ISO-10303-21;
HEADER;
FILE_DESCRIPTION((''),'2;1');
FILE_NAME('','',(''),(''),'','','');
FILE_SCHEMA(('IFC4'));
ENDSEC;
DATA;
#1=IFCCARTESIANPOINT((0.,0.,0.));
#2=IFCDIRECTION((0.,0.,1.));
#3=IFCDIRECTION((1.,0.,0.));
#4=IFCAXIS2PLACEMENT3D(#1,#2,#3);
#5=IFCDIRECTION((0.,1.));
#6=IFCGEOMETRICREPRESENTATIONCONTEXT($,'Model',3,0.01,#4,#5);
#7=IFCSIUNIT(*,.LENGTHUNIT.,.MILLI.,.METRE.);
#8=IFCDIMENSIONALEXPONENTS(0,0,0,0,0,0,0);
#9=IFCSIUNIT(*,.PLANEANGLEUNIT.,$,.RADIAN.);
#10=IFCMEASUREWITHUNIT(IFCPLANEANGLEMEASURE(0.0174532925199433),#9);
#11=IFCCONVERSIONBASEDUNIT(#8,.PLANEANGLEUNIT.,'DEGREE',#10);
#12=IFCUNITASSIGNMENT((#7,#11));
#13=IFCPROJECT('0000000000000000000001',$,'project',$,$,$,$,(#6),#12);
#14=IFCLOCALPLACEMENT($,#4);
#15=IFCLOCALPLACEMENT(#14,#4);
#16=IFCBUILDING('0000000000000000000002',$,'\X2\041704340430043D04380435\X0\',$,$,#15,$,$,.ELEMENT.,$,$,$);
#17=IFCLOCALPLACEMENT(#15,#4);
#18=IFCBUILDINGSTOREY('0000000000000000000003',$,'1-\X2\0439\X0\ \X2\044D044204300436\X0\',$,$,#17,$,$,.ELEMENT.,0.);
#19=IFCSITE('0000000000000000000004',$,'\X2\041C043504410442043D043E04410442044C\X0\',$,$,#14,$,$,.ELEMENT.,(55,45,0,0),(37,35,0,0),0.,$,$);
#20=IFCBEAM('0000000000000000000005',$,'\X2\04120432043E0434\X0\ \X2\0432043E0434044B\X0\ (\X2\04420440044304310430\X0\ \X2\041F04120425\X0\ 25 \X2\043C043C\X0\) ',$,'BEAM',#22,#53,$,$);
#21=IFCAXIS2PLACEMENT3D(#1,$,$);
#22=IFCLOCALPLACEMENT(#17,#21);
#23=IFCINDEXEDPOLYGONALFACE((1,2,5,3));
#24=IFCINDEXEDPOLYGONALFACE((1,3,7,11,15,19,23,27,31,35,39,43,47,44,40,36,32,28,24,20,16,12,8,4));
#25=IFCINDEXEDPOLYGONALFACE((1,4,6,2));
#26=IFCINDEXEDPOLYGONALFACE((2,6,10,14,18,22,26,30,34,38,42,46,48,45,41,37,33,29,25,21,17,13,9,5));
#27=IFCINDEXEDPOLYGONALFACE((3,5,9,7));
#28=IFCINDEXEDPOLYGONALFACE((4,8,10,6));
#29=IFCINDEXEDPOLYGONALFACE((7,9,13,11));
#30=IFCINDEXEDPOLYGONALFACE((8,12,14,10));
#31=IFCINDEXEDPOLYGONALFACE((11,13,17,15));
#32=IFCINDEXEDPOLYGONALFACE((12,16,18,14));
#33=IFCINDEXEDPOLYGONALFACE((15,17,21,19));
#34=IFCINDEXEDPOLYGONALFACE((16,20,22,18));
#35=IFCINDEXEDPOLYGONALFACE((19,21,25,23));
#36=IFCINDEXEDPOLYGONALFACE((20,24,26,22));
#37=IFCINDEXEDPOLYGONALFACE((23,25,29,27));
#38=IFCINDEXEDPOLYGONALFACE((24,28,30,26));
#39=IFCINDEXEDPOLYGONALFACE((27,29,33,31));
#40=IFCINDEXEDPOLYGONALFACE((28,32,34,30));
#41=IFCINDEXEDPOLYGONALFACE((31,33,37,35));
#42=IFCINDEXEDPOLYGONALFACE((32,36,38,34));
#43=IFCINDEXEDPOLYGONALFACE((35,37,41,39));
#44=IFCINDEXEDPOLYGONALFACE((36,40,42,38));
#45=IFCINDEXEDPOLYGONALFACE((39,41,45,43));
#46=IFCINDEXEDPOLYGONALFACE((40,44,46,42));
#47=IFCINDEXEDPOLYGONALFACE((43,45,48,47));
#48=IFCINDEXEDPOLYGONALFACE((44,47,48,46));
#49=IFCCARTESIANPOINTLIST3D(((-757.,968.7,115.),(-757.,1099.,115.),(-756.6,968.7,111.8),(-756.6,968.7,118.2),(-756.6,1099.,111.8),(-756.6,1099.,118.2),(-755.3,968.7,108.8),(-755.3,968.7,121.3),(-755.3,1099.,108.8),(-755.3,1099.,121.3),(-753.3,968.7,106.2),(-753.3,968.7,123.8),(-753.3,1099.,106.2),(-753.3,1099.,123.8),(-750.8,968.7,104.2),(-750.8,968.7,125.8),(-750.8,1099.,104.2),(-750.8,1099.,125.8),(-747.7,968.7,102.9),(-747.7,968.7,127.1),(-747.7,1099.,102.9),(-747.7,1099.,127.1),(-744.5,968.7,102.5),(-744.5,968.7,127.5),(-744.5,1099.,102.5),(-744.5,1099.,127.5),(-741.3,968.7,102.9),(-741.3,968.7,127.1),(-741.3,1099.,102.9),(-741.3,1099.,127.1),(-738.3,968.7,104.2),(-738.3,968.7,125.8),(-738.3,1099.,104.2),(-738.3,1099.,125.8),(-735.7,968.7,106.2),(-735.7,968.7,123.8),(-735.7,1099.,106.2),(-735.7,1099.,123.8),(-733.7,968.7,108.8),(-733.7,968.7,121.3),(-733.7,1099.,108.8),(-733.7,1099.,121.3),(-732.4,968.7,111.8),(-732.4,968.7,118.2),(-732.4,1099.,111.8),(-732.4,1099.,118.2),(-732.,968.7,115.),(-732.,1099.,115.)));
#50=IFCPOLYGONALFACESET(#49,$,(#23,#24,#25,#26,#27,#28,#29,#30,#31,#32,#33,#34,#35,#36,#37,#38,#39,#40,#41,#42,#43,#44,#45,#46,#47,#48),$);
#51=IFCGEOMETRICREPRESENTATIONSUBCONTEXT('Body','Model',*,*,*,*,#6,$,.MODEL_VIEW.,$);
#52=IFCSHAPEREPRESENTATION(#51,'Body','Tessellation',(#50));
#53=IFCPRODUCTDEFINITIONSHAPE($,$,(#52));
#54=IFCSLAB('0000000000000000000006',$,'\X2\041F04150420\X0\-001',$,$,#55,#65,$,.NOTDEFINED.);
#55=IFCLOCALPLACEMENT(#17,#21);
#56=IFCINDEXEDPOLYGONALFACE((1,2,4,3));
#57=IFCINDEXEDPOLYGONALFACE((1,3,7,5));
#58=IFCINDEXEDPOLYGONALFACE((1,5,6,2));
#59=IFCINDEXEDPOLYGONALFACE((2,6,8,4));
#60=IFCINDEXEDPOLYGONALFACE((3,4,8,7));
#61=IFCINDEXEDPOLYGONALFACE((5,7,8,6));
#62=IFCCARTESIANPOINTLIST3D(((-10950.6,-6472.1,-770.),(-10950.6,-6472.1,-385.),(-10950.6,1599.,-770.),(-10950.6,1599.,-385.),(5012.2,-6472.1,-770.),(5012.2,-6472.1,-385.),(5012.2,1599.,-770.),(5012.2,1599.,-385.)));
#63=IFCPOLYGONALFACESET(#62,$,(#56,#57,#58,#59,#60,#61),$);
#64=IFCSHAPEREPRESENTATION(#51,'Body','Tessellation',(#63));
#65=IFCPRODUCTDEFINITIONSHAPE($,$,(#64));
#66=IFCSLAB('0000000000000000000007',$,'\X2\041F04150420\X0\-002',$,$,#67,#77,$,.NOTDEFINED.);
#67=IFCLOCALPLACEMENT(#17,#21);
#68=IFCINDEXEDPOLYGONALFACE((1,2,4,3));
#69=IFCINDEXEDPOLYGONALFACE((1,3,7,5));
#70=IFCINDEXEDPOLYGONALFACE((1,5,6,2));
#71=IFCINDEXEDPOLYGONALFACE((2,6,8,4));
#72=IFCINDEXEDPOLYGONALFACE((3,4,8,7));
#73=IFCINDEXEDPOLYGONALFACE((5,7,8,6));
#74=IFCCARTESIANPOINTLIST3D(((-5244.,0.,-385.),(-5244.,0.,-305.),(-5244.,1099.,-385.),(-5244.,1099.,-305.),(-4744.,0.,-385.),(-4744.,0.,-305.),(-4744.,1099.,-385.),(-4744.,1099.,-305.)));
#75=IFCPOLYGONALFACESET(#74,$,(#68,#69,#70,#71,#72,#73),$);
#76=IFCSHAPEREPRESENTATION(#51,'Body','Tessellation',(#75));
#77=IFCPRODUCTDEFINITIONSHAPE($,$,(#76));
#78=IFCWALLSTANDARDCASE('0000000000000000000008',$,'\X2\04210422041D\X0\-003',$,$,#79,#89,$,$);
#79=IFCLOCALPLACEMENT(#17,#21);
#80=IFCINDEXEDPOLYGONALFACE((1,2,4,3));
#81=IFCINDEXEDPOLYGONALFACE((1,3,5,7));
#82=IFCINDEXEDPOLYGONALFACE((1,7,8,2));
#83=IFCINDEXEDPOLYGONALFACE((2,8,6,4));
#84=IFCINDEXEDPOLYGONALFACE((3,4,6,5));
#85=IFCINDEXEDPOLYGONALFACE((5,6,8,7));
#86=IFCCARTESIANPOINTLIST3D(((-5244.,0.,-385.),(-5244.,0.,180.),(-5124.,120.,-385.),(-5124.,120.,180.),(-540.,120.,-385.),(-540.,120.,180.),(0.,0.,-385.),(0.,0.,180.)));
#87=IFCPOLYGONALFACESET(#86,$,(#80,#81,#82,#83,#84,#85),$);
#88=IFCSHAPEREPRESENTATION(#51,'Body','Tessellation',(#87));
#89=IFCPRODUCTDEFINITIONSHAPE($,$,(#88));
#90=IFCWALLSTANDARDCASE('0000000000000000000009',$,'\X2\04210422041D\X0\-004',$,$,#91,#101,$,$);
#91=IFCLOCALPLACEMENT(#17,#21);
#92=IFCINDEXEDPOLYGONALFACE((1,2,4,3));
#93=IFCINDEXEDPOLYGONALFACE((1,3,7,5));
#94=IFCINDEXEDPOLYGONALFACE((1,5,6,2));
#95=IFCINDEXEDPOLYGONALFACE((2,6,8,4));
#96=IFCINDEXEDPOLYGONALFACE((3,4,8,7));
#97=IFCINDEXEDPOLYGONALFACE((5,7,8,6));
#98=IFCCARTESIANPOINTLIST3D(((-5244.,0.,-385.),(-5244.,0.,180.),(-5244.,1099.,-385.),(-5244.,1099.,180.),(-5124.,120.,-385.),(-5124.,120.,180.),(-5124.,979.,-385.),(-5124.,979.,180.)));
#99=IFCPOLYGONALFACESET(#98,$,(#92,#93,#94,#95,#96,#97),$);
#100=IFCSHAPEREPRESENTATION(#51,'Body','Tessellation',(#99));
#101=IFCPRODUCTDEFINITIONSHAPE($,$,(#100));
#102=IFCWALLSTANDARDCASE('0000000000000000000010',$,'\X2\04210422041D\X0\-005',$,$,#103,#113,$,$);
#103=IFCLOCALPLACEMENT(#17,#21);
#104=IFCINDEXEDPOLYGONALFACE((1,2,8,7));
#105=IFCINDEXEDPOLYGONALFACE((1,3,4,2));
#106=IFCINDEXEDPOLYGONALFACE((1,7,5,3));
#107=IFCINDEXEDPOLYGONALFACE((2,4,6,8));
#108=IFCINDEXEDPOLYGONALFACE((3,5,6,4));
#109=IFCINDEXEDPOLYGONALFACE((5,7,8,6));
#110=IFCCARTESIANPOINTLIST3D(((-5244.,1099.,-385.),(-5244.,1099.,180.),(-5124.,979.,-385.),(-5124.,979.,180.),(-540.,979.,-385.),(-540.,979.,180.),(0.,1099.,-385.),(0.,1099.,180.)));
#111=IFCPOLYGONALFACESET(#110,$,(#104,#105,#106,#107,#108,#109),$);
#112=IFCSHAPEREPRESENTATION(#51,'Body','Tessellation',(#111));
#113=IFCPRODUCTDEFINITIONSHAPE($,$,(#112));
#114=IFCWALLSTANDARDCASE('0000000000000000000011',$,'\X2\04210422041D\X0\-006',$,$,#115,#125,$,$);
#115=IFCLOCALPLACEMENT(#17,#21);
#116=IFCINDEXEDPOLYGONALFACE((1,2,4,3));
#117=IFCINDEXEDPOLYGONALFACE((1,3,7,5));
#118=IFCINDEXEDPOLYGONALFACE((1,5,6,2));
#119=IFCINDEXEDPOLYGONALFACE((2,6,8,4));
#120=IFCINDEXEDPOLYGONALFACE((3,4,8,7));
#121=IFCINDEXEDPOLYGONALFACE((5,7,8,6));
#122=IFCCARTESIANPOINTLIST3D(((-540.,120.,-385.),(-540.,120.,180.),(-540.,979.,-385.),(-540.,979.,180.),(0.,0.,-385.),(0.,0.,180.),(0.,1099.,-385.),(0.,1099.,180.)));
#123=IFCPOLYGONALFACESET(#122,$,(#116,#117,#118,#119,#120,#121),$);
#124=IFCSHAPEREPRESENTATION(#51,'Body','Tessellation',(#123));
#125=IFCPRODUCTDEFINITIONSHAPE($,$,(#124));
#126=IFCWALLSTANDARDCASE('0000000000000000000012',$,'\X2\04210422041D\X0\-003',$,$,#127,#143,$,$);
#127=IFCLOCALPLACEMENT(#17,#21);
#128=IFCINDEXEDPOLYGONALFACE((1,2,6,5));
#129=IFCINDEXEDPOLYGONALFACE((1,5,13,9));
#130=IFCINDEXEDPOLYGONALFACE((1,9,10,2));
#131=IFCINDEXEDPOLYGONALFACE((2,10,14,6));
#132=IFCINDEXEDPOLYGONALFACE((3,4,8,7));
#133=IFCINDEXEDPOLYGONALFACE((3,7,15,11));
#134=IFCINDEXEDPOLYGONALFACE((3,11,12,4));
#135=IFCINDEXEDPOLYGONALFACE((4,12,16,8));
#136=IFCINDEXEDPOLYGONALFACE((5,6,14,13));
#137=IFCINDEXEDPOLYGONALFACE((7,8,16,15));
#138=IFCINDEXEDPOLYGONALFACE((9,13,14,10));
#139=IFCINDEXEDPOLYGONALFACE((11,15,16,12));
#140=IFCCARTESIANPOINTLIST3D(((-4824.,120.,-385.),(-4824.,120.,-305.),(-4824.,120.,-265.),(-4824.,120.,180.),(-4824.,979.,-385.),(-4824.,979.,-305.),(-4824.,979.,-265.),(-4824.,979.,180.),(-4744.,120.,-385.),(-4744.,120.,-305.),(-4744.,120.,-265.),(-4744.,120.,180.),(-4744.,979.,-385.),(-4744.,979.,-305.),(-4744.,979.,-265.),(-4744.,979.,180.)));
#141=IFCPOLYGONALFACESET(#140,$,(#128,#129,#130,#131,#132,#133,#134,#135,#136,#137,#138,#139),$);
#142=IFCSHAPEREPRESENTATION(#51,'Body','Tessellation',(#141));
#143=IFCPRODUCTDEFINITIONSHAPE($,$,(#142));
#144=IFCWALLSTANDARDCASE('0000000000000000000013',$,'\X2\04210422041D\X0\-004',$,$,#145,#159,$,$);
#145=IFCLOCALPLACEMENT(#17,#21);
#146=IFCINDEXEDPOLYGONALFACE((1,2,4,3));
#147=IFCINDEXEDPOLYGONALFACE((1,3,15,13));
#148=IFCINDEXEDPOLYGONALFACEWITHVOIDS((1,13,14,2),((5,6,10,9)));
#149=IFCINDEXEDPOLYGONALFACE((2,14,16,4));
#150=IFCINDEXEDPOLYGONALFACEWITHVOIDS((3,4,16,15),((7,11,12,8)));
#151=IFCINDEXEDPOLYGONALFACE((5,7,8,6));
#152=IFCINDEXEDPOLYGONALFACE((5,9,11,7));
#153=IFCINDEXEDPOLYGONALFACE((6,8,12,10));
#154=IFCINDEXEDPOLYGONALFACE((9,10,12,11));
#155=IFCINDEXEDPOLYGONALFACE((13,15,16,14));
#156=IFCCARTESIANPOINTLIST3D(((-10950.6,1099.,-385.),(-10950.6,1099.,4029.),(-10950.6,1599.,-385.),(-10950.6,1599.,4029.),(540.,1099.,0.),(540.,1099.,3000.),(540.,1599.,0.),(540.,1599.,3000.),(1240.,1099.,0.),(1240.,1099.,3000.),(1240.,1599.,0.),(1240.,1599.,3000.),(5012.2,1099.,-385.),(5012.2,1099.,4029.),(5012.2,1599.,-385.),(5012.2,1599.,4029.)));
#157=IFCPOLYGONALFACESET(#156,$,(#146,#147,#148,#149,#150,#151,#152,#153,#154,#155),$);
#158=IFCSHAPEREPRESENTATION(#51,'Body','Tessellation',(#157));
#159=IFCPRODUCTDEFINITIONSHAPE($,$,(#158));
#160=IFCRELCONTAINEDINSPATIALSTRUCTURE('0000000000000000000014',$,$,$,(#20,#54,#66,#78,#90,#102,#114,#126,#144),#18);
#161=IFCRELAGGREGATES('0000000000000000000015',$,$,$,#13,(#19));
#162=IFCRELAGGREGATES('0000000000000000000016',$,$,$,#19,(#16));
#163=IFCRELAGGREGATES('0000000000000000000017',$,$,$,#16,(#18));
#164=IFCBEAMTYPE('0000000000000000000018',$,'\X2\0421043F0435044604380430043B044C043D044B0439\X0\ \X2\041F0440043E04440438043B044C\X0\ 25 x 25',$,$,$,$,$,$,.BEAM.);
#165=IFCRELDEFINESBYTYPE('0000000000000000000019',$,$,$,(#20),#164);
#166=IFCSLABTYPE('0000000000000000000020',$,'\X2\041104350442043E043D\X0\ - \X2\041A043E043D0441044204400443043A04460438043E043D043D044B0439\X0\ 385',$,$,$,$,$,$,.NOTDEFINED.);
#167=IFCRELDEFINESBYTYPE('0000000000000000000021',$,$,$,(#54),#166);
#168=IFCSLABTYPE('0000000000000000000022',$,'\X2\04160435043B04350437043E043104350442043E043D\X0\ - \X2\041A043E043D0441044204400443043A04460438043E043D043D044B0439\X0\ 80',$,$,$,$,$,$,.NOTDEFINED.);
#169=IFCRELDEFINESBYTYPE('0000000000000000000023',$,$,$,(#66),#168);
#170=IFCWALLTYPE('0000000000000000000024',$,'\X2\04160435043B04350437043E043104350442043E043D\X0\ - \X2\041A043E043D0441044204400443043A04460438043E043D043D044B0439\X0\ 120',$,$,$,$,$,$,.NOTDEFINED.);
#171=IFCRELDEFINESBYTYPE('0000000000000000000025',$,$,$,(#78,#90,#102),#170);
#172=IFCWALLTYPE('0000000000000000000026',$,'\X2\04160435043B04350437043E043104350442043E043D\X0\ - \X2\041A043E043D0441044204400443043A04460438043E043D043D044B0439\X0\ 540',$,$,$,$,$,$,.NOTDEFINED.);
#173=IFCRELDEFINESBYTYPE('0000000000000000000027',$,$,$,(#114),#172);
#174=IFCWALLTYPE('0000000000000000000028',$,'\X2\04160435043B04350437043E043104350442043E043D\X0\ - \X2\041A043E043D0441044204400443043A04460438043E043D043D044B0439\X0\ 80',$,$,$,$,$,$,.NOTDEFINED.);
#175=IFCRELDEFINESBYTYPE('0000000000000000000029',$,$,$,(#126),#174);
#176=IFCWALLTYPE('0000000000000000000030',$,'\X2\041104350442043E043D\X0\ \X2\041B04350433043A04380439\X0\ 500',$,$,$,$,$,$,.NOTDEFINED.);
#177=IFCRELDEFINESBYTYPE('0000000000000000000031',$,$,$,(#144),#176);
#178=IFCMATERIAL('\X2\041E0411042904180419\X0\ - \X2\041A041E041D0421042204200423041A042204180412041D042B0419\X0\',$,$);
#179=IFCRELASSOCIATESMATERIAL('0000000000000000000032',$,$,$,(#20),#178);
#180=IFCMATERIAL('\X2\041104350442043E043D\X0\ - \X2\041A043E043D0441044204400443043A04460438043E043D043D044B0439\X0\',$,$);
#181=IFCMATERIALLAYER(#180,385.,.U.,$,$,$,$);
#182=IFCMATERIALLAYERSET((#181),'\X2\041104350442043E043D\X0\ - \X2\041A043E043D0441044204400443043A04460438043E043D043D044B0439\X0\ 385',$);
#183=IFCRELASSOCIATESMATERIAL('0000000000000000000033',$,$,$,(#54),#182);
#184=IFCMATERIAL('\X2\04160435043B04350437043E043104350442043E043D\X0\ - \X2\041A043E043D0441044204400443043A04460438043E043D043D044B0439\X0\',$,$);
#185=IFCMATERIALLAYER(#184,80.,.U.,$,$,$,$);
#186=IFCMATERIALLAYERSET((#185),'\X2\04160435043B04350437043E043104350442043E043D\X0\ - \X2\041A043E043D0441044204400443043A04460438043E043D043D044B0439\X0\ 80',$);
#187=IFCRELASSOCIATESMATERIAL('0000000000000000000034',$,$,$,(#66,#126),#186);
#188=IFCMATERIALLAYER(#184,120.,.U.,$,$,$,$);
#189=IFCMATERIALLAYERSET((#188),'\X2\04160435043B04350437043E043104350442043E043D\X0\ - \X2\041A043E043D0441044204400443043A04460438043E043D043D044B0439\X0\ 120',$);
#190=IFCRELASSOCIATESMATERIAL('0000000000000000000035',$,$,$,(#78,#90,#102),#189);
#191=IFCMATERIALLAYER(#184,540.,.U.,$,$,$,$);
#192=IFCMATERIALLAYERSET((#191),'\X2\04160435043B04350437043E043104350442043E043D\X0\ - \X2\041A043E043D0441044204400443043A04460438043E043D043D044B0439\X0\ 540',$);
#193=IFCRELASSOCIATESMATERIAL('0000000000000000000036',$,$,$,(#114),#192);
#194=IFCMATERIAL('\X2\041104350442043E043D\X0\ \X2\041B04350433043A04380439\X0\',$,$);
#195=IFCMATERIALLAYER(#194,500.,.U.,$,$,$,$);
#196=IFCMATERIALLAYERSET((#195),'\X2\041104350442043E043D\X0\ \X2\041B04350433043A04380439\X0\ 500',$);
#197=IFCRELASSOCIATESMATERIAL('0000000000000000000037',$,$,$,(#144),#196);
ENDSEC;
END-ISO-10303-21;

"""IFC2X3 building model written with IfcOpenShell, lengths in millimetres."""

from ifc_helpers import new_model, entity, si_unit, converted_unit, point, direction, frame, frame_2d, origin_with_axes, origin_2d_with_axis, place, context, subcontext, project, spatial, polyline, circle_curve, parameter, trimmed, segment, composite_curve, rectangle, outline, extrude, material, layer, layer_set, layer_usage, type_object, element, save


model = new_model("IFC2X3")

# Units and contexts
model_context = context("Model", 3, precision=0.01, world=origin_with_axes(), true_north=direction((0.0, 1.0)))
body_context = subcontext(model_context, "Body", "Model", "MODEL_VIEW")
ifc_project = project(units=[si_unit("LENGTHUNIT", "METRE", prefix="MILLI"), converted_unit("PLANEANGLEUNIT", "DEGREE", entity("IfcPlaneAngleMeasure", 0.0174532925199433), si_unit("PLANEANGLEUNIT", "RADIAN"), dimensions=[0, 0, 0, 0, 0, 0, 0])], contexts=[model_context])

# Site, building, storey
site_placement = place(None, origin_with_axes())
site = spatial("IfcSite", under=ifc_project, at=site_placement, Name="Местность", CompositionType="ELEMENT", RefLatitude=(55, 45, 0, 0), RefLongitude=(37, 35, 0, 0), RefElevation=0.0)
building_placement = place(site_placement, origin_with_axes())
building = spatial("IfcBuilding", under=site, at=building_placement, Name="Здание", CompositionType="ELEMENT")
storey_placement = place(building_placement, origin_with_axes())
storey = spatial("IfcBuildingStorey", under=building, at=storey_placement, Name="1-й этаж", CompositionType="ELEMENT", Elevation=0.0)

# Beam
ifc_material_1 = material(Name="ОБЩИЙ - КОНСТРУКТИВНЫЙ")
beam_type = type_object("IfcBeamType", Name="Специальный Профиль 25 x 25", PredefinedType="BEAM")
beam_placement = place(storey_placement, frame((-744.5, 1099.0, 115.0), z_axis=(0.0, 0.0, 1.0), x_axis=(-1.0, 0.0, 0.0)))
element("IfcBeam", 1, at=beam_placement, inside=storey, type_object=beam_type, material=ifc_material_1, Name="Ввод воды (труба ПВХ 25 мм) ", ObjectType="BEAM", context=body_context, shape_type="SweptSolid", body=[
    extrude(outline(composite_curve([segment(trimmed(circle_curve(frame_2d((0.0, 0.0), x_axis=(-1.0, 0.0)), 12.5), [point((-12.5, 0.0)), parameter(0.0)], [point((0.0, -12.5)), parameter(90.0)], True, "CARTESIAN"), True, "CONTINUOUS"), segment(trimmed(circle_curve(frame_2d((0.0, 0.0), x_axis=(0.0, -1.0)), 12.5), [point((0.0, -12.5)), parameter(0.0)], [point((12.5, 0.0)), parameter(90.0)], True, "CARTESIAN"), True, "CONTINUOUS"), segment(trimmed(circle_curve(origin_2d_with_axis(), 12.5), [point((12.5, 0.0)), parameter(0.0)], [point((0.0, 12.5)), parameter(90.0)], True, "CARTESIAN"), True, "CONTINUOUS"), segment(trimmed(circle_curve(frame_2d((0.0, 0.0), x_axis=(0.0, 1.0)), 12.5), [point((0.0, 12.5)), parameter(0.0)], [point((-12.5, 0.0)), parameter(90.0)], True, "CARTESIAN"), True, "CONTINUOUS")], self_intersect=False)), frame((0.0, 130.3, 0.0), z_axis=(0.0, -1.0, 0.0), x_axis=(1.0, 0.0, 0.0)), (0.0, 0.0, 1.0), 130.3),
])

# Slabs
ifc_material_2 = material(Name="Бетон - Конструкционный")
ifc_layer_1 = layer(ifc_material_2, 385.0, ventilated="UNKNOWN")
ifc_layer_set_1 = layer_set([ifc_layer_1], Name="Бетон - Конструкционный 385")
ifc_layer_usage_1 = layer_usage(ifc_layer_set_1, "AXIS3", "NEGATIVE", 385.0)
slab_type_1 = type_object("IfcSlabType", Name="Бетон - Конструкционный 385", PredefinedType="NOTDEFINED")
slab_1_placement = place(storey_placement, frame((-10950.6, -6472.1, -385.0), z_axis=(0.0, 0.0, 1.0), x_axis=(1.0, 0.0, 0.0)))
element("IfcSlab", 2, at=slab_1_placement, inside=storey, type_object=slab_type_1, material=ifc_layer_usage_1, Name="ПЕР-001", PredefinedType="NOTDEFINED", context=body_context, shape_type="SweptSolid", body=[
    extrude(outline(polyline([(0.0, 0.0), (15962.8, 0.0), (15962.8, 8071.1), (0.0, 8071.1), (0.0, 0.0)])), frame((0.0, 0.0, -385.0), z_axis=(0.0, 0.0, 1.0), x_axis=(1.0, 0.0, 0.0)), (0.0, 0.0, 1.0), 385.0),
])
ifc_material_3 = material(Name="Железобетон - Конструкционный")
ifc_layer_2 = layer(ifc_material_3, 80.0, ventilated="UNKNOWN")
ifc_layer_set_2 = layer_set([ifc_layer_2], Name="Железобетон - Конструкционный 80")
ifc_layer_usage_2 = layer_usage(ifc_layer_set_2, "AXIS3", "NEGATIVE", 80.0)
slab_type_2 = type_object("IfcSlabType", Name="Железобетон - Конструкционный 80", PredefinedType="NOTDEFINED")
slab_2_placement = place(storey_placement, frame((-5244.0, 0.0, -305.0), z_axis=(0.0, 0.0, 1.0), x_axis=(1.0, 0.0, 0.0)))
element("IfcSlab", 3, at=slab_2_placement, inside=storey, type_object=slab_type_2, material=ifc_layer_usage_2, Name="ПЕР-002", PredefinedType="NOTDEFINED", context=body_context, shape_type="SweptSolid", body=[
    extrude(outline(polyline([(0.0, 0.0), (500.0, 0.0), (500.0, 1099.0), (0.0, 1099.0), (0.0, 0.0)])), frame((0.0, 0.0, -80.0), z_axis=(0.0, 0.0, 1.0), x_axis=(1.0, 0.0, 0.0)), (0.0, 0.0, 1.0), 80.0),
])

# Walls
ifc_layer_3 = layer(ifc_material_3, 120.0, ventilated="UNKNOWN")
ifc_layer_set_3 = layer_set([ifc_layer_3], Name="Железобетон - Конструкционный 120")
ifc_layer_usage_3 = layer_usage(ifc_layer_set_3, "AXIS2", "NEGATIVE", 0.0)
wall_type_1 = type_object("IfcWallType", Name="Железобетон - Конструкционный 120", PredefinedType="NOTDEFINED")
wall_1_placement = place(storey_placement, frame((0.0, 0.0, -385.0), z_axis=(0.0, 0.0, 1.0), x_axis=(-1.0, 0.0, 0.0)))
element("IfcWallStandardCase", 4, at=wall_1_placement, inside=storey, type_object=wall_type_1, material=ifc_layer_usage_3, Name="СТН-003", context=body_context, shape_type="SweptSolid", body=[
    extrude(outline(polyline([(540.0, -120.0), (5124.0, -120.0), (5244.0, 0.0), (0.0, 0.0), (540.0, -120.0)])), origin_with_axes(), (0.0, 0.0, 1.0), 565.0),
])
ifc_layer_usage_4 = layer_usage(ifc_layer_set_3, "AXIS2", "NEGATIVE", 0.0)
wall_2_placement = place(storey_placement, frame((-5244.0, 0.0, -385.0), z_axis=(0.0, 0.0, 1.0), x_axis=(0.0, 1.0, 0.0)))
element("IfcWallStandardCase", 5, at=wall_2_placement, inside=storey, type_object=wall_type_1, material=ifc_layer_usage_4, Name="СТН-004", context=body_context, shape_type="SweptSolid", body=[
    extrude(outline(polyline([(120.0, -120.0), (979.0, -120.0), (1099.0, 0.0), (0.0, 0.0), (120.0, -120.0)])), origin_with_axes(), (0.0, 0.0, 1.0), 565.0),
])
ifc_layer_usage_5 = layer_usage(ifc_layer_set_3, "AXIS2", "NEGATIVE", 0.0)
wall_3_placement = place(storey_placement, frame((-5244.0, 1099.0, -385.0), z_axis=(0.0, 0.0, 1.0), x_axis=(1.0, 0.0, 0.0)))
element("IfcWallStandardCase", 6, at=wall_3_placement, inside=storey, type_object=wall_type_1, material=ifc_layer_usage_5, Name="СТН-005", context=body_context, shape_type="SweptSolid", body=[
    extrude(outline(polyline([(120.0, -120.0), (4704.0, -120.0), (5244.0, 0.0), (0.0, 0.0), (120.0, -120.0)])), origin_with_axes(), (0.0, 0.0, 1.0), 565.0),
])
ifc_layer_4 = layer(ifc_material_3, 540.0, ventilated="UNKNOWN")
ifc_layer_set_4 = layer_set([ifc_layer_4], Name="Железобетон - Конструкционный 540")
ifc_layer_usage_6 = layer_usage(ifc_layer_set_4, "AXIS2", "NEGATIVE", 0.0)
wall_type_2 = type_object("IfcWallType", Name="Железобетон - Конструкционный 540", PredefinedType="NOTDEFINED")
wall_4_placement = place(storey_placement, frame((0.0, 1099.0, -385.0), z_axis=(0.0, 0.0, 1.0), x_axis=(0.0, -1.0, 0.0)))
element("IfcWallStandardCase", 7, at=wall_4_placement, inside=storey, type_object=wall_type_2, material=ifc_layer_usage_6, Name="СТН-006", context=body_context, shape_type="SweptSolid", body=[
    extrude(outline(polyline([(120.0, -540.0), (979.0, -540.0), (1099.0, 0.0), (0.0, 0.0), (120.0, -540.0)])), origin_with_axes(), (0.0, 0.0, 1.0), 565.0),
])

# Wall, openings
ifc_layer_usage_7 = layer_usage(ifc_layer_set_2, "AXIS2", "NEGATIVE", 0.0)
wall_type_3 = type_object("IfcWallType", Name="Железобетон - Конструкционный 80", PredefinedType="NOTDEFINED")
wall_5_placement = place(storey_placement, frame((-4824.0, 0.0, -385.0), z_axis=(0.0, 0.0, 1.0), x_axis=(0.0, 1.0, 0.0)))
wall_5 = element("IfcWallStandardCase", 8, at=wall_5_placement, inside=storey, type_object=wall_type_3, material=ifc_layer_usage_7, Name="СТН-003", context=body_context, shape_type="SweptSolid", body=[
    extrude(outline(polyline([(120.0, -80.0), (979.0, -80.0), (979.0, 0.0), (120.0, 0.0), (120.0, -80.0)])), origin_with_axes(), (0.0, 0.0, 1.0), 565.0),
])
opening_1_placement = place(wall_5_placement, frame((527.4, 0.0, 1285.0), z_axis=(0.0, 0.0, 1.0), x_axis=(1.0, 0.0, 0.0)))
element("IfcOpeningElement", 9, at=opening_1_placement, cuts=wall_5, context=body_context, shape_type="SweptSolid", body=[
    extrude(rectangle(XDim=900.0, YDim=80.0, at=origin_2d_with_axis()), frame((0.0, -80.0, 40.0), z_axis=(0.0, 1.0, 0.0), x_axis=(1.0, 0.0, 0.0)), (0.0, 0.0, -1.0), 80.0),
    extrude(rectangle(XDim=900.0, YDim=80.0, at=origin_2d_with_axis()), frame((0.0, -80.0, 40.0), z_axis=(0.0, -1.0, 0.0), x_axis=(1.0, 0.0, 0.0)), (0.0, 0.0, -1.0), 80.0),
])
opening_2_placement = place(wall_5_placement, frame((0.0, -4824.0, 385.0), z_axis=(0.0, 0.0, 1.0), x_axis=(0.0, -1.0, 0.0)))
element("IfcOpeningElement", 10, at=opening_2_placement, cuts=wall_5, context=body_context, shape_type="SweptSolid", body=[
    extrude(rectangle(XDim=859.0, YDim=40.0, at=origin_2d_with_axis()), frame((-4664.0, 549.5, -285.0), z_axis=(1.0, 0.0, 0.0), x_axis=(0.0, 1.0, 0.0)), (0.0, 0.0, -1.0), 240.0),
])

# Wall, opening
ifc_material_4 = material(Name="Бетон Легкий")
ifc_layer_5 = layer(ifc_material_4, 500.0, ventilated="UNKNOWN")
ifc_layer_set_5 = layer_set([ifc_layer_5], Name="Бетон Легкий 500")
ifc_layer_usage_8 = layer_usage(ifc_layer_set_5, "AXIS2", "NEGATIVE", 0.0)
wall_type_4 = type_object("IfcWallType", Name="Бетон Легкий 500", PredefinedType="NOTDEFINED")
wall_6_placement = place(storey_placement, frame((-10950.6, 1599.0, -385.0), z_axis=(0.0, 0.0, 1.0), x_axis=(1.0, 0.0, 0.0)))
wall_6 = element("IfcWallStandardCase", 11, at=wall_6_placement, inside=storey, type_object=wall_type_4, material=ifc_layer_usage_8, Name="СТН-004", context=body_context, shape_type="SweptSolid", body=[
    extrude(outline(polyline([(0.0, -500.0), (15962.8, -500.0), (15962.8, 0.0), (0.0, 0.0), (0.0, -500.0)])), origin_with_axes(), (0.0, 0.0, 1.0), 4414.0),
])
opening_3_placement = place(wall_6_placement, frame((11840.6, 0.0, 385.0), z_axis=(0.0, 0.0, 1.0), x_axis=(1.0, 0.0, 0.0)))
element("IfcOpeningElement", 12, at=opening_3_placement, cuts=wall_6, context=body_context, shape_type="SweptSolid", body=[
    extrude(rectangle(XDim=700.0, YDim=3000.0, at=origin_2d_with_axis()), frame((0.0, 0.0, 1500.0), z_axis=(0.0, -1.0, 0.0), x_axis=(1.0, 0.0, 0.0)), (0.0, 0.0, -1.0), 500.0),
    extrude(rectangle(XDim=700.0, YDim=3000.0, at=origin_2d_with_axis()), frame((0.0, 0.0, 1500.0), z_axis=(0.0, 1.0, 0.0), x_axis=(1.0, 0.0, 0.0)), (0.0, 0.0, -1.0), 500.0),
])

save(model, "model.ifc")
